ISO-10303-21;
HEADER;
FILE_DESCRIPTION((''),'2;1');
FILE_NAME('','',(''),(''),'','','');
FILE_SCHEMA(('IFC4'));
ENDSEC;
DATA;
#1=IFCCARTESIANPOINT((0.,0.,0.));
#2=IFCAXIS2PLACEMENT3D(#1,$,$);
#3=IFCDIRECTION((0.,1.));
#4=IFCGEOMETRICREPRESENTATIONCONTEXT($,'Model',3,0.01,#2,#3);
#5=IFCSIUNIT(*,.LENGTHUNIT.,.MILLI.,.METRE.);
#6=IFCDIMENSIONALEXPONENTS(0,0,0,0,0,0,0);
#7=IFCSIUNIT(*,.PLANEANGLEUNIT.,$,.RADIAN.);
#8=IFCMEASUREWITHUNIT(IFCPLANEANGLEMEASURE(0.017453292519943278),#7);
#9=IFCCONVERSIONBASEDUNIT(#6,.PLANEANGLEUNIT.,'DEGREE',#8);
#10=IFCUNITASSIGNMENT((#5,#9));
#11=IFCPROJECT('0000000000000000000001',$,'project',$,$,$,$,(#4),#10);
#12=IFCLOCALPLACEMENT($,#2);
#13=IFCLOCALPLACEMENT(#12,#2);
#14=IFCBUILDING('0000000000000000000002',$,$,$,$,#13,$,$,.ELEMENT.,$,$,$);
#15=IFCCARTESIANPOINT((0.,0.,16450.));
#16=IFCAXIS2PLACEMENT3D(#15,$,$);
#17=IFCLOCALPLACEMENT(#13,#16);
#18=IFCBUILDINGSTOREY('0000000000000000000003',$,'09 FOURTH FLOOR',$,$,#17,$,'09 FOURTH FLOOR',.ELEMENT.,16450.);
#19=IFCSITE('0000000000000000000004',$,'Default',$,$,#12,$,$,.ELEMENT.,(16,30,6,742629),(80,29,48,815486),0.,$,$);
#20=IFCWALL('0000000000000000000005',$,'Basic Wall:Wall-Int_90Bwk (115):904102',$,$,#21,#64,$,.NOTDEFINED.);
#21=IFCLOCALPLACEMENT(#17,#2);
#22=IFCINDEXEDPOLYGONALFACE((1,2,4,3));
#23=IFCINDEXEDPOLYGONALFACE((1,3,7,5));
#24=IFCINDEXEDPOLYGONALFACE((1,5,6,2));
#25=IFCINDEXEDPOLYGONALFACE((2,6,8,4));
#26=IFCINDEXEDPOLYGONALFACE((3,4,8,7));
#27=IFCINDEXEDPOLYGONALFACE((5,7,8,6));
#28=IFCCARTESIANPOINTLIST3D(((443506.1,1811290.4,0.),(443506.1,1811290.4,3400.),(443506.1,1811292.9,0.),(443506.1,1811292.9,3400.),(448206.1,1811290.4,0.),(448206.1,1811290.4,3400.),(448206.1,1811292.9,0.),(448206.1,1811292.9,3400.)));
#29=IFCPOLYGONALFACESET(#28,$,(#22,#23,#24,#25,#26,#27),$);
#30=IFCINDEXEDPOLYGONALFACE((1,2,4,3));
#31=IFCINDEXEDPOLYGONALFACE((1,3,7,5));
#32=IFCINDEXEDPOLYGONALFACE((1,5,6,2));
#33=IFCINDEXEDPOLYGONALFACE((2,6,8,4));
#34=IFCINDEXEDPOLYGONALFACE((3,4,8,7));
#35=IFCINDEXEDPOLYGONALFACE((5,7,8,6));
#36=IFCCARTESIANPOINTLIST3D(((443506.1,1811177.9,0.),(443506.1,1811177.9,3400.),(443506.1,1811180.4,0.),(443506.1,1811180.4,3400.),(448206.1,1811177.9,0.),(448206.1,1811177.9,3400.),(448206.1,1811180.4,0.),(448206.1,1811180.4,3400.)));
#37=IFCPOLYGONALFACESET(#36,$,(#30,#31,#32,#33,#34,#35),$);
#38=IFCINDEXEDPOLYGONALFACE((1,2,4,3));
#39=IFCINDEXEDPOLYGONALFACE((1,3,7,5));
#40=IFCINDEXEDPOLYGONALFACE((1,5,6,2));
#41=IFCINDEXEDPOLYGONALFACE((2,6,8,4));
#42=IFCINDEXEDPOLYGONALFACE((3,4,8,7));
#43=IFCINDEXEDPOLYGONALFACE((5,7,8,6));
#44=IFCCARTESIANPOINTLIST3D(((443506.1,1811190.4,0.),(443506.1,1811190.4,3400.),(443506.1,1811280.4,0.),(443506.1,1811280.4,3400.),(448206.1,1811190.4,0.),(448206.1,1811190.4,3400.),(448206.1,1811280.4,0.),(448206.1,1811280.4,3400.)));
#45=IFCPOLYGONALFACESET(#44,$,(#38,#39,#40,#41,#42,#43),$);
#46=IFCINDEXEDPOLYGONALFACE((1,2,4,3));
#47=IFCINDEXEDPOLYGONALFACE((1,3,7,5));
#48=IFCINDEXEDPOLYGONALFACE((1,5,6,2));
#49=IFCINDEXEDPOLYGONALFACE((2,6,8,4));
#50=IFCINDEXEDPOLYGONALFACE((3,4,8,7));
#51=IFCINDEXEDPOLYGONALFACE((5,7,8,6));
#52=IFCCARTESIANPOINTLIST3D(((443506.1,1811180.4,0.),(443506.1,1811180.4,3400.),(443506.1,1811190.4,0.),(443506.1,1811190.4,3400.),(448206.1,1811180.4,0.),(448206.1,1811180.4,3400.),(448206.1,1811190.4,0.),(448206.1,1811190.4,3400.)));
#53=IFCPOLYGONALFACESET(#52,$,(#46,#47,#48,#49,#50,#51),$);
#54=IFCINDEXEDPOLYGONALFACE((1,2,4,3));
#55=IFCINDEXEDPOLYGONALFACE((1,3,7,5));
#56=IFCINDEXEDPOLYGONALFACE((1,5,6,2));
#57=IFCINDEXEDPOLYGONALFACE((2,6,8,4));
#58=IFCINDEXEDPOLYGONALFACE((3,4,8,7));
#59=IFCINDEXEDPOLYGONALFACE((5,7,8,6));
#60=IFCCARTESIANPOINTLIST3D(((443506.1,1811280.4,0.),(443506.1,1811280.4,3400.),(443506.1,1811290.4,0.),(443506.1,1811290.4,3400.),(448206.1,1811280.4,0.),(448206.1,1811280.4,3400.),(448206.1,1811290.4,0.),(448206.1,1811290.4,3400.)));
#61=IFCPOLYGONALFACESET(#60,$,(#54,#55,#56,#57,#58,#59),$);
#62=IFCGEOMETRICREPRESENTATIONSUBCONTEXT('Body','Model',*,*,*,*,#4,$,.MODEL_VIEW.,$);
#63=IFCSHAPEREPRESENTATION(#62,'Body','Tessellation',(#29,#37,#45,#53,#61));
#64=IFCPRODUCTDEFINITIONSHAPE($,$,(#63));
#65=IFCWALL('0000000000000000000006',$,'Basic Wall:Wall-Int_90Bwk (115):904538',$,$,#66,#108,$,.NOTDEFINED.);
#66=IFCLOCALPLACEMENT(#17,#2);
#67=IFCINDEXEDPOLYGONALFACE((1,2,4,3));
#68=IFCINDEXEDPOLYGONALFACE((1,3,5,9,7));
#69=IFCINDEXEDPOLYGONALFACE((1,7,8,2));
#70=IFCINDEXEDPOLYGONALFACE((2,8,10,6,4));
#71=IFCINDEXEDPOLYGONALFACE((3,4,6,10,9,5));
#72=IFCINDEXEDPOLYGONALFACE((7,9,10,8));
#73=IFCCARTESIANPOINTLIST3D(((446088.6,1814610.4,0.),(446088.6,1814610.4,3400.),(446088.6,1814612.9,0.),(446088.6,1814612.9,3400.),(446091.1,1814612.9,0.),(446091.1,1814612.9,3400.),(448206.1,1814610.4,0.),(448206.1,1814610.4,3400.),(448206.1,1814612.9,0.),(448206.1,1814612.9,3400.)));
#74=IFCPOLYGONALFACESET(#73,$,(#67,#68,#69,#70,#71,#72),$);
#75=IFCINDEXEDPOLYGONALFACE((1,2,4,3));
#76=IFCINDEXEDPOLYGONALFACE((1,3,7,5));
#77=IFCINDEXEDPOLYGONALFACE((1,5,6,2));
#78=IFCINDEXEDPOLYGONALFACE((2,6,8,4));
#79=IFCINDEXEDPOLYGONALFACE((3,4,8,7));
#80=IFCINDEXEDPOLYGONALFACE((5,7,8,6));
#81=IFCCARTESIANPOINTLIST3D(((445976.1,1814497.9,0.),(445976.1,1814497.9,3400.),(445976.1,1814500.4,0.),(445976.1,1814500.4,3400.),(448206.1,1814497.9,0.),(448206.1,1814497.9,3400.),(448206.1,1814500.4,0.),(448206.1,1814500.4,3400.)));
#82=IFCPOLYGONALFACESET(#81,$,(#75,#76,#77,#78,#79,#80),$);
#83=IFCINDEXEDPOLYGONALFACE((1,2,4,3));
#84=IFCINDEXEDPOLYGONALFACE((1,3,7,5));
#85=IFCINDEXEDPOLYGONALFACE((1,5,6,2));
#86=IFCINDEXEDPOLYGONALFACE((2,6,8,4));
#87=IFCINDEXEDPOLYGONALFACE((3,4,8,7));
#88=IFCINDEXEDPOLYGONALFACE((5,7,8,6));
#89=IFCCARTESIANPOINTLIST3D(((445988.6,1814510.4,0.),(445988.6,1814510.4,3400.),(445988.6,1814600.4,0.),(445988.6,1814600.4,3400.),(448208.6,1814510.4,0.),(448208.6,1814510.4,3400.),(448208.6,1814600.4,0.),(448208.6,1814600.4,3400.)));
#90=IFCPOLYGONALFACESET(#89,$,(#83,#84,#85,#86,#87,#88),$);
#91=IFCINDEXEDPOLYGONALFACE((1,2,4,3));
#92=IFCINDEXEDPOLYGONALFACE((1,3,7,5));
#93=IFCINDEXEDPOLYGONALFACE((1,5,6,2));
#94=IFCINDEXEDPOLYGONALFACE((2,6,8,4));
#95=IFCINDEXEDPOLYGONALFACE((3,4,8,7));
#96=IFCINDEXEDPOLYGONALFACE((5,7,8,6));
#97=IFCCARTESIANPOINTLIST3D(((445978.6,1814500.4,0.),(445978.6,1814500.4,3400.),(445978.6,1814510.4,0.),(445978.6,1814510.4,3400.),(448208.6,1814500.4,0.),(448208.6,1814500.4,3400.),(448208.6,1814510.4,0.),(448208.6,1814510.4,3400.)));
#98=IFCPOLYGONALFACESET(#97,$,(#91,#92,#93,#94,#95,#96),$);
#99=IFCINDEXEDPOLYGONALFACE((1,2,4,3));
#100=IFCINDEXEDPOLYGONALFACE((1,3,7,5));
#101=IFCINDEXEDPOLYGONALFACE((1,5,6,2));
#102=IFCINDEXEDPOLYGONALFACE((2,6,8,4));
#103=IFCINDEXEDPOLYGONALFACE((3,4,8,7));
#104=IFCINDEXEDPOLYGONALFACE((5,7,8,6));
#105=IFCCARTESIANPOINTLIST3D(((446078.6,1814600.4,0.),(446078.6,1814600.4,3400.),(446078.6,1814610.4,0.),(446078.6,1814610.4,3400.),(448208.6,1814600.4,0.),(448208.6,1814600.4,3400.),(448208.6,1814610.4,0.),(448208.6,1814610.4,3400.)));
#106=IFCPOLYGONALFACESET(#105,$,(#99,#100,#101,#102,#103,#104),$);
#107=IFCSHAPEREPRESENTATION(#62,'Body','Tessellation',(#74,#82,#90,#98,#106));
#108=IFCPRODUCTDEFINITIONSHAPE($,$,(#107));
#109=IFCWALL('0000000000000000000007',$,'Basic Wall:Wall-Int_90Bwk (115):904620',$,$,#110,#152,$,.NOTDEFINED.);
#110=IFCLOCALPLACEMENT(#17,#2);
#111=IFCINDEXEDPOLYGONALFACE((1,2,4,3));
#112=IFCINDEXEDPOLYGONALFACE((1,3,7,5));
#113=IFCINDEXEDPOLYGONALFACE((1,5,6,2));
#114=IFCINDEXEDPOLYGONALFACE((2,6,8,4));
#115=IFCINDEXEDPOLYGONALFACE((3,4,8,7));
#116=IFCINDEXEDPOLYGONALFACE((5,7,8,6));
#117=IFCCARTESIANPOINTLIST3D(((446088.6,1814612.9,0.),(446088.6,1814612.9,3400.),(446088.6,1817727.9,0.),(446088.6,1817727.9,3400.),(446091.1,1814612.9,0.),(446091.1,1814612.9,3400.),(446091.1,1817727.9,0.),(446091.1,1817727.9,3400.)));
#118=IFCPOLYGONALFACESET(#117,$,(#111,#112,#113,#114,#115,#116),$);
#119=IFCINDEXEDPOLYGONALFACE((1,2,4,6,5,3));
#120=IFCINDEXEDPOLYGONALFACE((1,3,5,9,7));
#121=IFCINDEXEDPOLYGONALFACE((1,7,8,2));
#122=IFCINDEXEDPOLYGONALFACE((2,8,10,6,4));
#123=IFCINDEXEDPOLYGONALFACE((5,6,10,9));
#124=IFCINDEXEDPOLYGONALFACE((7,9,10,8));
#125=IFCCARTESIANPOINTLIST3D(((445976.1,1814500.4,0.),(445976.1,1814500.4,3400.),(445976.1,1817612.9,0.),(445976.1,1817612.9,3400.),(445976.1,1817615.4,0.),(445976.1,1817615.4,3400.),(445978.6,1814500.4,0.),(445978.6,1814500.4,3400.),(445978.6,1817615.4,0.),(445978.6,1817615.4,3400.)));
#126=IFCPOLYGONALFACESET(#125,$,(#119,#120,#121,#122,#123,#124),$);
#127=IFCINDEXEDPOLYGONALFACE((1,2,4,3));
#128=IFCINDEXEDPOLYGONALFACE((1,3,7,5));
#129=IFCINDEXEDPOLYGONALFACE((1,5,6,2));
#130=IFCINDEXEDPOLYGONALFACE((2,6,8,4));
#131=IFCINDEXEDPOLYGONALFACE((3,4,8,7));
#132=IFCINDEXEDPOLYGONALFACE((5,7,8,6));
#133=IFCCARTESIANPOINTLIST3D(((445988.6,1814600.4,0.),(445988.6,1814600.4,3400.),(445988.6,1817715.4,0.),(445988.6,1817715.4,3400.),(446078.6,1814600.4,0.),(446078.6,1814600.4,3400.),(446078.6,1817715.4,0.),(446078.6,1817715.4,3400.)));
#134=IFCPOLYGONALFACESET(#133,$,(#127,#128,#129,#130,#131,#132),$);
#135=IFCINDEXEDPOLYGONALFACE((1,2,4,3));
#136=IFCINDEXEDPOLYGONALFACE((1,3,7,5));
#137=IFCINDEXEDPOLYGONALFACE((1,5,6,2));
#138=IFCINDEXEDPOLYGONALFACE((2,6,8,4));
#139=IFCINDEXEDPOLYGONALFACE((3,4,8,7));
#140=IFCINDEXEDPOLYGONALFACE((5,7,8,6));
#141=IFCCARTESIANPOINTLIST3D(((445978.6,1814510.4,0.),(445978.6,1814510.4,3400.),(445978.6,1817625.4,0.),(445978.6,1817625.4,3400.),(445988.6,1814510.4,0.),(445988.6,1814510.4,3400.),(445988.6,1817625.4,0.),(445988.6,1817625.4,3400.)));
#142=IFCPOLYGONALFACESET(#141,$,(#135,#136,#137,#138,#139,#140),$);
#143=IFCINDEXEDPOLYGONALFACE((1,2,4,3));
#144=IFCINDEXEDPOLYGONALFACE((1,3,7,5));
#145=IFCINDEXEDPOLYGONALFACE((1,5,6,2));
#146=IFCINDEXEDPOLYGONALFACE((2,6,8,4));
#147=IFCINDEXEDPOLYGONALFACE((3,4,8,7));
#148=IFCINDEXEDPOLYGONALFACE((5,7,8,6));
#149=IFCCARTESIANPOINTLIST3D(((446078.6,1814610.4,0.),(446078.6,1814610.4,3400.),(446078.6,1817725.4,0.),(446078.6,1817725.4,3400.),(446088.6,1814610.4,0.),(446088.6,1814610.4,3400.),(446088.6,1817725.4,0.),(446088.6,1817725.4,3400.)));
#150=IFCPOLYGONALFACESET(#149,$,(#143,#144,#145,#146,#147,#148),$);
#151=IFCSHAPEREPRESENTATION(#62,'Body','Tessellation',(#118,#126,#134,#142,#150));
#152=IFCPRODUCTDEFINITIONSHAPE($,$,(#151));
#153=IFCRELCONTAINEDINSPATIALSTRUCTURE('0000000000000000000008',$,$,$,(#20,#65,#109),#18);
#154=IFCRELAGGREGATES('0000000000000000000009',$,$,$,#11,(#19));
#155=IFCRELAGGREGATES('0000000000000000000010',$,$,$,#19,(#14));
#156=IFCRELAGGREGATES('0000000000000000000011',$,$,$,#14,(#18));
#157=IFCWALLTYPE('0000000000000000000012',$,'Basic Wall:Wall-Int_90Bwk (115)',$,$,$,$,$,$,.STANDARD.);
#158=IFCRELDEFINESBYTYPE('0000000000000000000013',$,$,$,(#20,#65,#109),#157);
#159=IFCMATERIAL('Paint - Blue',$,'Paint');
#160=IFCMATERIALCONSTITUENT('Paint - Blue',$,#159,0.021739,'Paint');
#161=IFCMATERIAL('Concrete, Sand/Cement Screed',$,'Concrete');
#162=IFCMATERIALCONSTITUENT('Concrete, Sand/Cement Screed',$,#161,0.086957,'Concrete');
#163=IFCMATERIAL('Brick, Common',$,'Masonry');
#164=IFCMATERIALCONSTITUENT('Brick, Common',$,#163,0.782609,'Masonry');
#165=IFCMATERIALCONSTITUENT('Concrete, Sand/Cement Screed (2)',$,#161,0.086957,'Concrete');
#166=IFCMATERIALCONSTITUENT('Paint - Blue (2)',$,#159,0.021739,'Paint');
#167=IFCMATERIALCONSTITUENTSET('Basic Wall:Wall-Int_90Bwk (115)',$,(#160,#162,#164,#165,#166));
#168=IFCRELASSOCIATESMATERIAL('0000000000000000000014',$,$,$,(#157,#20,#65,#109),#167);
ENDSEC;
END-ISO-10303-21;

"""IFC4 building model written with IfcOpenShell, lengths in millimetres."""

from ifc_helpers import new_model, entity, si_unit, converted_unit, direction, frame, origin, place, context, subcontext, project, spatial, indexed_curve, outline, extrude, material, constituent, constituent_set, type_object, element, save


model = new_model("IFC4")

# Units and contexts
model_context = context("Model", 3, precision=0.01, world=origin(), true_north=direction((0.0, 1.0)))
body_context = subcontext(model_context, "Body", "Model", "MODEL_VIEW")
ifc_project = project(units=[si_unit("LENGTHUNIT", "METRE", prefix="MILLI"), converted_unit("PLANEANGLEUNIT", "DEGREE", entity("IfcPlaneAngleMeasure", 0.017453292519943278), si_unit("PLANEANGLEUNIT", "RADIAN"), dimensions=[0, 0, 0, 0, 0, 0, 0])], contexts=[model_context])

# Site, building, storey
site_placement = place(None, origin())
site = spatial("IfcSite", under=ifc_project, at=site_placement, Name="Default", CompositionType="ELEMENT", RefLatitude=(16, 30, 6, 742629), RefLongitude=(80, 29, 48, 815486), RefElevation=0.0)
building_placement = place(site_placement, origin())
building = spatial("IfcBuilding", under=site, at=building_placement, CompositionType="ELEMENT")
storey_placement = place(building_placement, frame((0.0, 0.0, 16450.0)))
storey = spatial("IfcBuildingStorey", under=building, at=storey_placement, Name="09 FOURTH FLOOR", LongName="09 FOURTH FLOOR", CompositionType="ELEMENT", Elevation=16450.0)

# Wall
ifc_material_1 = material(Name="Paint - Blue", Category="Paint")
ifc_constituent_1 = constituent(ifc_material_1, Name="Paint - Blue", Category="Paint", fraction=0.021739)
ifc_material_2 = material(Name="Concrete, Sand/Cement Screed", Category="Concrete")
ifc_constituent_2 = constituent(ifc_material_2, Name="Concrete, Sand/Cement Screed", Category="Concrete", fraction=0.086957)
ifc_material_3 = material(Name="Brick, Common", Category="Masonry")
ifc_constituent_3 = constituent(ifc_material_3, Name="Brick, Common", Category="Masonry", fraction=0.782609)
ifc_constituent_4 = constituent(ifc_material_2, Name="Concrete, Sand/Cement Screed (2)", Category="Concrete", fraction=0.086957)
ifc_constituent_5 = constituent(ifc_material_1, Name="Paint - Blue (2)", Category="Paint", fraction=0.021739)
ifc_constituent_set_1 = constituent_set(constituents=[ifc_constituent_1, ifc_constituent_2, ifc_constituent_3, ifc_constituent_4, ifc_constituent_5], Name="Basic Wall:Wall-Int_90Bwk (115)")
wall_type_1 = type_object("IfcWallType", Name="Basic Wall:Wall-Int_90Bwk (115)", PredefinedType="STANDARD", material=ifc_constituent_set_1)
wall_1_placement = place(storey_placement, frame((443506.1, 1811235.4, 0.0)))
element("IfcWall", 1, at=wall_1_placement, inside=storey, type_object=wall_type_1, material=ifc_constituent_set_1, Name="Basic Wall:Wall-Int_90Bwk (115):904102", PredefinedType="NOTDEFINED", context=body_context, shape_type="SweptSolid", body=[
    extrude(outline(indexed_curve([(-1.3, -2350.0), (1.3, -2350.0), (1.3, 2350.0), (-1.3, 2350.0), (-1.3, -2350.0)], self_intersect=False)), frame((2350.0, 56.3, 0.0), z_axis=(0.0, 0.0, 1.0), x_axis=(0.0, -1.0, 0.0)), (0.0, 0.0, 1.0), 3400.0),
    extrude(outline(indexed_curve([(-1.2, -2350.0), (1.3, -2350.0), (1.3, 2350.0), (-1.2, 2350.0), (-1.2, -2350.0)], self_intersect=False)), frame((2350.0, -56.3, 0.0), z_axis=(0.0, 0.0, 1.0), x_axis=(0.0, 1.0, 0.0)), (0.0, 0.0, 1.0), 3400.0),
    extrude(outline(indexed_curve([(-2350.0, -45.0), (2350.0, -45.0), (2350.0, 45.0), (-2350.0, 45.0), (-2350.0, -45.0)], self_intersect=False)), frame((2350.0, 0.0, 0.0)), (0.0, 0.0, 1.0), 3400.0),
    extrude(outline(indexed_curve([(-2350.0, -5.0), (2350.0, -5.0), (2350.0, 5.0), (-2350.0, 5.0), (-2350.0, -5.0)], self_intersect=False)), frame((2350.0, -50.0, 0.0)), (0.0, 0.0, 1.0), 3400.0),
    extrude(outline(indexed_curve([(-2350.0, -5.0), (2350.0, -5.0), (2350.0, 5.0), (-2350.0, 5.0), (-2350.0, -5.0)], self_intersect=False)), frame((2350.0, 50.0, 0.0)), (0.0, 0.0, 1.0), 3400.0),
])

# Walls
wall_2_placement = place(storey_placement, frame((448206.1, 1814555.4, 0.0), z_axis=(0.0, 0.0, 1.0), x_axis=(-1.0, 0.0, 0.0)))
element("IfcWall", 2, at=wall_2_placement, inside=storey, type_object=wall_type_1, material=ifc_constituent_set_1, Name="Basic Wall:Wall-Int_90Bwk (115):904538", PredefinedType="NOTDEFINED", context=body_context, shape_type="SweptSolid", body=[
    extrude(outline(indexed_curve([(845.0, -1.0), (847.5, -1.0), (847.5, 1.5), (-1270.0, 1.5), (-1270.0, -1.0), (845.0, -1.0)], self_intersect=False)), frame((1270.0, -56.5, 0.0)), (0.0, 0.0, 1.0), 3400.0),
    extrude(outline(indexed_curve([(-1.3, -1115.0), (1.3, -1115.0), (1.3, 1115.0), (-1.3, 1115.0), (-1.3, -1115.0)], self_intersect=False)), frame((1115.0, 56.3, 0.0), z_axis=(0.0, 0.0, 1.0), x_axis=(0.0, -1.0, 0.0)), (0.0, 0.0, 1.0), 3400.0),
    extrude(outline(indexed_curve([(-1110.0, -45.0), (1110.0, -45.0), (1110.0, 45.0), (-1110.0, 45.0), (-1110.0, -45.0)], self_intersect=False)), frame((1107.5, 0.0, 0.0)), (0.0, 0.0, 1.0), 3400.0),
    extrude(outline(indexed_curve([(-1115.0, -5.0), (1115.0, -5.0), (1115.0, 5.0), (-1115.0, 5.0), (-1115.0, -5.0)], self_intersect=False)), frame((1112.5, 50.0, 0.0)), (0.0, 0.0, 1.0), 3400.0),
    extrude(outline(indexed_curve([(-1065.0, -5.0), (1065.0, -5.0), (1065.0, 5.0), (-1065.0, 5.0), (-1065.0, -5.0)], self_intersect=False)), frame((1062.5, -50.0, 0.0)), (0.0, 0.0, 1.0), 3400.0),
])
wall_3_placement = place(storey_placement, frame((446033.6, 1814612.9, 0.0), z_axis=(0.0, 0.0, 1.0), x_axis=(0.0, 1.0, 0.0)))
element("IfcWall", 3, at=wall_3_placement, inside=storey, type_object=wall_type_1, material=ifc_constituent_set_1, Name="Basic Wall:Wall-Int_90Bwk (115):904620", PredefinedType="NOTDEFINED", context=body_context, shape_type="SweptSolid", body=[
    extrude(outline(indexed_curve([(-1.3, -1557.5), (1.2, -1557.5), (1.2, 1557.5), (-1.3, 1557.5), (-1.3, -1557.5)], self_intersect=False)), frame((1557.5, -56.2, 0.0), z_axis=(0.0, 0.0, 1.0), x_axis=(0.0, 1.0, 0.0)), (0.0, 0.0, 1.0), 3400.0),
    extrude(outline(indexed_curve([(-1244.0, -1.0), (1868.5, -1.0), (1868.5, 1.5), (-1246.5, 1.5), (-1246.5, -1.0), (-1244.0, -1.0)], self_intersect=False)), frame((1756.0, 56.5, 0.0), z_axis=(0.0, 0.0, 1.0), x_axis=(-1.0, 0.0, 0.0)), (0.0, 0.0, 1.0), 3400.0),
    extrude(outline(indexed_curve([(-1557.5, -45.0), (1557.5, -45.0), (1557.5, 45.0), (-1557.5, 45.0), (-1557.5, -45.0)], self_intersect=False)), frame((1545.0, 0.0, 0.0)), (0.0, 0.0, 1.0), 3400.0),
    extrude(outline(indexed_curve([(-1557.5, -5.0), (1557.5, -5.0), (1557.5, 5.0), (-1557.5, 5.0), (-1557.5, -5.0)], self_intersect=False)), frame((1455.0, 50.0, 0.0)), (0.0, 0.0, 1.0), 3400.0),
    extrude(outline(indexed_curve([(-1557.5, -5.0), (1557.5, -5.0), (1557.5, 5.0), (-1557.5, 5.0), (-1557.5, -5.0)], self_intersect=False)), frame((1555.0, -50.0, 0.0)), (0.0, 0.0, 1.0), 3400.0),
])

save(model, "model.ifc")
